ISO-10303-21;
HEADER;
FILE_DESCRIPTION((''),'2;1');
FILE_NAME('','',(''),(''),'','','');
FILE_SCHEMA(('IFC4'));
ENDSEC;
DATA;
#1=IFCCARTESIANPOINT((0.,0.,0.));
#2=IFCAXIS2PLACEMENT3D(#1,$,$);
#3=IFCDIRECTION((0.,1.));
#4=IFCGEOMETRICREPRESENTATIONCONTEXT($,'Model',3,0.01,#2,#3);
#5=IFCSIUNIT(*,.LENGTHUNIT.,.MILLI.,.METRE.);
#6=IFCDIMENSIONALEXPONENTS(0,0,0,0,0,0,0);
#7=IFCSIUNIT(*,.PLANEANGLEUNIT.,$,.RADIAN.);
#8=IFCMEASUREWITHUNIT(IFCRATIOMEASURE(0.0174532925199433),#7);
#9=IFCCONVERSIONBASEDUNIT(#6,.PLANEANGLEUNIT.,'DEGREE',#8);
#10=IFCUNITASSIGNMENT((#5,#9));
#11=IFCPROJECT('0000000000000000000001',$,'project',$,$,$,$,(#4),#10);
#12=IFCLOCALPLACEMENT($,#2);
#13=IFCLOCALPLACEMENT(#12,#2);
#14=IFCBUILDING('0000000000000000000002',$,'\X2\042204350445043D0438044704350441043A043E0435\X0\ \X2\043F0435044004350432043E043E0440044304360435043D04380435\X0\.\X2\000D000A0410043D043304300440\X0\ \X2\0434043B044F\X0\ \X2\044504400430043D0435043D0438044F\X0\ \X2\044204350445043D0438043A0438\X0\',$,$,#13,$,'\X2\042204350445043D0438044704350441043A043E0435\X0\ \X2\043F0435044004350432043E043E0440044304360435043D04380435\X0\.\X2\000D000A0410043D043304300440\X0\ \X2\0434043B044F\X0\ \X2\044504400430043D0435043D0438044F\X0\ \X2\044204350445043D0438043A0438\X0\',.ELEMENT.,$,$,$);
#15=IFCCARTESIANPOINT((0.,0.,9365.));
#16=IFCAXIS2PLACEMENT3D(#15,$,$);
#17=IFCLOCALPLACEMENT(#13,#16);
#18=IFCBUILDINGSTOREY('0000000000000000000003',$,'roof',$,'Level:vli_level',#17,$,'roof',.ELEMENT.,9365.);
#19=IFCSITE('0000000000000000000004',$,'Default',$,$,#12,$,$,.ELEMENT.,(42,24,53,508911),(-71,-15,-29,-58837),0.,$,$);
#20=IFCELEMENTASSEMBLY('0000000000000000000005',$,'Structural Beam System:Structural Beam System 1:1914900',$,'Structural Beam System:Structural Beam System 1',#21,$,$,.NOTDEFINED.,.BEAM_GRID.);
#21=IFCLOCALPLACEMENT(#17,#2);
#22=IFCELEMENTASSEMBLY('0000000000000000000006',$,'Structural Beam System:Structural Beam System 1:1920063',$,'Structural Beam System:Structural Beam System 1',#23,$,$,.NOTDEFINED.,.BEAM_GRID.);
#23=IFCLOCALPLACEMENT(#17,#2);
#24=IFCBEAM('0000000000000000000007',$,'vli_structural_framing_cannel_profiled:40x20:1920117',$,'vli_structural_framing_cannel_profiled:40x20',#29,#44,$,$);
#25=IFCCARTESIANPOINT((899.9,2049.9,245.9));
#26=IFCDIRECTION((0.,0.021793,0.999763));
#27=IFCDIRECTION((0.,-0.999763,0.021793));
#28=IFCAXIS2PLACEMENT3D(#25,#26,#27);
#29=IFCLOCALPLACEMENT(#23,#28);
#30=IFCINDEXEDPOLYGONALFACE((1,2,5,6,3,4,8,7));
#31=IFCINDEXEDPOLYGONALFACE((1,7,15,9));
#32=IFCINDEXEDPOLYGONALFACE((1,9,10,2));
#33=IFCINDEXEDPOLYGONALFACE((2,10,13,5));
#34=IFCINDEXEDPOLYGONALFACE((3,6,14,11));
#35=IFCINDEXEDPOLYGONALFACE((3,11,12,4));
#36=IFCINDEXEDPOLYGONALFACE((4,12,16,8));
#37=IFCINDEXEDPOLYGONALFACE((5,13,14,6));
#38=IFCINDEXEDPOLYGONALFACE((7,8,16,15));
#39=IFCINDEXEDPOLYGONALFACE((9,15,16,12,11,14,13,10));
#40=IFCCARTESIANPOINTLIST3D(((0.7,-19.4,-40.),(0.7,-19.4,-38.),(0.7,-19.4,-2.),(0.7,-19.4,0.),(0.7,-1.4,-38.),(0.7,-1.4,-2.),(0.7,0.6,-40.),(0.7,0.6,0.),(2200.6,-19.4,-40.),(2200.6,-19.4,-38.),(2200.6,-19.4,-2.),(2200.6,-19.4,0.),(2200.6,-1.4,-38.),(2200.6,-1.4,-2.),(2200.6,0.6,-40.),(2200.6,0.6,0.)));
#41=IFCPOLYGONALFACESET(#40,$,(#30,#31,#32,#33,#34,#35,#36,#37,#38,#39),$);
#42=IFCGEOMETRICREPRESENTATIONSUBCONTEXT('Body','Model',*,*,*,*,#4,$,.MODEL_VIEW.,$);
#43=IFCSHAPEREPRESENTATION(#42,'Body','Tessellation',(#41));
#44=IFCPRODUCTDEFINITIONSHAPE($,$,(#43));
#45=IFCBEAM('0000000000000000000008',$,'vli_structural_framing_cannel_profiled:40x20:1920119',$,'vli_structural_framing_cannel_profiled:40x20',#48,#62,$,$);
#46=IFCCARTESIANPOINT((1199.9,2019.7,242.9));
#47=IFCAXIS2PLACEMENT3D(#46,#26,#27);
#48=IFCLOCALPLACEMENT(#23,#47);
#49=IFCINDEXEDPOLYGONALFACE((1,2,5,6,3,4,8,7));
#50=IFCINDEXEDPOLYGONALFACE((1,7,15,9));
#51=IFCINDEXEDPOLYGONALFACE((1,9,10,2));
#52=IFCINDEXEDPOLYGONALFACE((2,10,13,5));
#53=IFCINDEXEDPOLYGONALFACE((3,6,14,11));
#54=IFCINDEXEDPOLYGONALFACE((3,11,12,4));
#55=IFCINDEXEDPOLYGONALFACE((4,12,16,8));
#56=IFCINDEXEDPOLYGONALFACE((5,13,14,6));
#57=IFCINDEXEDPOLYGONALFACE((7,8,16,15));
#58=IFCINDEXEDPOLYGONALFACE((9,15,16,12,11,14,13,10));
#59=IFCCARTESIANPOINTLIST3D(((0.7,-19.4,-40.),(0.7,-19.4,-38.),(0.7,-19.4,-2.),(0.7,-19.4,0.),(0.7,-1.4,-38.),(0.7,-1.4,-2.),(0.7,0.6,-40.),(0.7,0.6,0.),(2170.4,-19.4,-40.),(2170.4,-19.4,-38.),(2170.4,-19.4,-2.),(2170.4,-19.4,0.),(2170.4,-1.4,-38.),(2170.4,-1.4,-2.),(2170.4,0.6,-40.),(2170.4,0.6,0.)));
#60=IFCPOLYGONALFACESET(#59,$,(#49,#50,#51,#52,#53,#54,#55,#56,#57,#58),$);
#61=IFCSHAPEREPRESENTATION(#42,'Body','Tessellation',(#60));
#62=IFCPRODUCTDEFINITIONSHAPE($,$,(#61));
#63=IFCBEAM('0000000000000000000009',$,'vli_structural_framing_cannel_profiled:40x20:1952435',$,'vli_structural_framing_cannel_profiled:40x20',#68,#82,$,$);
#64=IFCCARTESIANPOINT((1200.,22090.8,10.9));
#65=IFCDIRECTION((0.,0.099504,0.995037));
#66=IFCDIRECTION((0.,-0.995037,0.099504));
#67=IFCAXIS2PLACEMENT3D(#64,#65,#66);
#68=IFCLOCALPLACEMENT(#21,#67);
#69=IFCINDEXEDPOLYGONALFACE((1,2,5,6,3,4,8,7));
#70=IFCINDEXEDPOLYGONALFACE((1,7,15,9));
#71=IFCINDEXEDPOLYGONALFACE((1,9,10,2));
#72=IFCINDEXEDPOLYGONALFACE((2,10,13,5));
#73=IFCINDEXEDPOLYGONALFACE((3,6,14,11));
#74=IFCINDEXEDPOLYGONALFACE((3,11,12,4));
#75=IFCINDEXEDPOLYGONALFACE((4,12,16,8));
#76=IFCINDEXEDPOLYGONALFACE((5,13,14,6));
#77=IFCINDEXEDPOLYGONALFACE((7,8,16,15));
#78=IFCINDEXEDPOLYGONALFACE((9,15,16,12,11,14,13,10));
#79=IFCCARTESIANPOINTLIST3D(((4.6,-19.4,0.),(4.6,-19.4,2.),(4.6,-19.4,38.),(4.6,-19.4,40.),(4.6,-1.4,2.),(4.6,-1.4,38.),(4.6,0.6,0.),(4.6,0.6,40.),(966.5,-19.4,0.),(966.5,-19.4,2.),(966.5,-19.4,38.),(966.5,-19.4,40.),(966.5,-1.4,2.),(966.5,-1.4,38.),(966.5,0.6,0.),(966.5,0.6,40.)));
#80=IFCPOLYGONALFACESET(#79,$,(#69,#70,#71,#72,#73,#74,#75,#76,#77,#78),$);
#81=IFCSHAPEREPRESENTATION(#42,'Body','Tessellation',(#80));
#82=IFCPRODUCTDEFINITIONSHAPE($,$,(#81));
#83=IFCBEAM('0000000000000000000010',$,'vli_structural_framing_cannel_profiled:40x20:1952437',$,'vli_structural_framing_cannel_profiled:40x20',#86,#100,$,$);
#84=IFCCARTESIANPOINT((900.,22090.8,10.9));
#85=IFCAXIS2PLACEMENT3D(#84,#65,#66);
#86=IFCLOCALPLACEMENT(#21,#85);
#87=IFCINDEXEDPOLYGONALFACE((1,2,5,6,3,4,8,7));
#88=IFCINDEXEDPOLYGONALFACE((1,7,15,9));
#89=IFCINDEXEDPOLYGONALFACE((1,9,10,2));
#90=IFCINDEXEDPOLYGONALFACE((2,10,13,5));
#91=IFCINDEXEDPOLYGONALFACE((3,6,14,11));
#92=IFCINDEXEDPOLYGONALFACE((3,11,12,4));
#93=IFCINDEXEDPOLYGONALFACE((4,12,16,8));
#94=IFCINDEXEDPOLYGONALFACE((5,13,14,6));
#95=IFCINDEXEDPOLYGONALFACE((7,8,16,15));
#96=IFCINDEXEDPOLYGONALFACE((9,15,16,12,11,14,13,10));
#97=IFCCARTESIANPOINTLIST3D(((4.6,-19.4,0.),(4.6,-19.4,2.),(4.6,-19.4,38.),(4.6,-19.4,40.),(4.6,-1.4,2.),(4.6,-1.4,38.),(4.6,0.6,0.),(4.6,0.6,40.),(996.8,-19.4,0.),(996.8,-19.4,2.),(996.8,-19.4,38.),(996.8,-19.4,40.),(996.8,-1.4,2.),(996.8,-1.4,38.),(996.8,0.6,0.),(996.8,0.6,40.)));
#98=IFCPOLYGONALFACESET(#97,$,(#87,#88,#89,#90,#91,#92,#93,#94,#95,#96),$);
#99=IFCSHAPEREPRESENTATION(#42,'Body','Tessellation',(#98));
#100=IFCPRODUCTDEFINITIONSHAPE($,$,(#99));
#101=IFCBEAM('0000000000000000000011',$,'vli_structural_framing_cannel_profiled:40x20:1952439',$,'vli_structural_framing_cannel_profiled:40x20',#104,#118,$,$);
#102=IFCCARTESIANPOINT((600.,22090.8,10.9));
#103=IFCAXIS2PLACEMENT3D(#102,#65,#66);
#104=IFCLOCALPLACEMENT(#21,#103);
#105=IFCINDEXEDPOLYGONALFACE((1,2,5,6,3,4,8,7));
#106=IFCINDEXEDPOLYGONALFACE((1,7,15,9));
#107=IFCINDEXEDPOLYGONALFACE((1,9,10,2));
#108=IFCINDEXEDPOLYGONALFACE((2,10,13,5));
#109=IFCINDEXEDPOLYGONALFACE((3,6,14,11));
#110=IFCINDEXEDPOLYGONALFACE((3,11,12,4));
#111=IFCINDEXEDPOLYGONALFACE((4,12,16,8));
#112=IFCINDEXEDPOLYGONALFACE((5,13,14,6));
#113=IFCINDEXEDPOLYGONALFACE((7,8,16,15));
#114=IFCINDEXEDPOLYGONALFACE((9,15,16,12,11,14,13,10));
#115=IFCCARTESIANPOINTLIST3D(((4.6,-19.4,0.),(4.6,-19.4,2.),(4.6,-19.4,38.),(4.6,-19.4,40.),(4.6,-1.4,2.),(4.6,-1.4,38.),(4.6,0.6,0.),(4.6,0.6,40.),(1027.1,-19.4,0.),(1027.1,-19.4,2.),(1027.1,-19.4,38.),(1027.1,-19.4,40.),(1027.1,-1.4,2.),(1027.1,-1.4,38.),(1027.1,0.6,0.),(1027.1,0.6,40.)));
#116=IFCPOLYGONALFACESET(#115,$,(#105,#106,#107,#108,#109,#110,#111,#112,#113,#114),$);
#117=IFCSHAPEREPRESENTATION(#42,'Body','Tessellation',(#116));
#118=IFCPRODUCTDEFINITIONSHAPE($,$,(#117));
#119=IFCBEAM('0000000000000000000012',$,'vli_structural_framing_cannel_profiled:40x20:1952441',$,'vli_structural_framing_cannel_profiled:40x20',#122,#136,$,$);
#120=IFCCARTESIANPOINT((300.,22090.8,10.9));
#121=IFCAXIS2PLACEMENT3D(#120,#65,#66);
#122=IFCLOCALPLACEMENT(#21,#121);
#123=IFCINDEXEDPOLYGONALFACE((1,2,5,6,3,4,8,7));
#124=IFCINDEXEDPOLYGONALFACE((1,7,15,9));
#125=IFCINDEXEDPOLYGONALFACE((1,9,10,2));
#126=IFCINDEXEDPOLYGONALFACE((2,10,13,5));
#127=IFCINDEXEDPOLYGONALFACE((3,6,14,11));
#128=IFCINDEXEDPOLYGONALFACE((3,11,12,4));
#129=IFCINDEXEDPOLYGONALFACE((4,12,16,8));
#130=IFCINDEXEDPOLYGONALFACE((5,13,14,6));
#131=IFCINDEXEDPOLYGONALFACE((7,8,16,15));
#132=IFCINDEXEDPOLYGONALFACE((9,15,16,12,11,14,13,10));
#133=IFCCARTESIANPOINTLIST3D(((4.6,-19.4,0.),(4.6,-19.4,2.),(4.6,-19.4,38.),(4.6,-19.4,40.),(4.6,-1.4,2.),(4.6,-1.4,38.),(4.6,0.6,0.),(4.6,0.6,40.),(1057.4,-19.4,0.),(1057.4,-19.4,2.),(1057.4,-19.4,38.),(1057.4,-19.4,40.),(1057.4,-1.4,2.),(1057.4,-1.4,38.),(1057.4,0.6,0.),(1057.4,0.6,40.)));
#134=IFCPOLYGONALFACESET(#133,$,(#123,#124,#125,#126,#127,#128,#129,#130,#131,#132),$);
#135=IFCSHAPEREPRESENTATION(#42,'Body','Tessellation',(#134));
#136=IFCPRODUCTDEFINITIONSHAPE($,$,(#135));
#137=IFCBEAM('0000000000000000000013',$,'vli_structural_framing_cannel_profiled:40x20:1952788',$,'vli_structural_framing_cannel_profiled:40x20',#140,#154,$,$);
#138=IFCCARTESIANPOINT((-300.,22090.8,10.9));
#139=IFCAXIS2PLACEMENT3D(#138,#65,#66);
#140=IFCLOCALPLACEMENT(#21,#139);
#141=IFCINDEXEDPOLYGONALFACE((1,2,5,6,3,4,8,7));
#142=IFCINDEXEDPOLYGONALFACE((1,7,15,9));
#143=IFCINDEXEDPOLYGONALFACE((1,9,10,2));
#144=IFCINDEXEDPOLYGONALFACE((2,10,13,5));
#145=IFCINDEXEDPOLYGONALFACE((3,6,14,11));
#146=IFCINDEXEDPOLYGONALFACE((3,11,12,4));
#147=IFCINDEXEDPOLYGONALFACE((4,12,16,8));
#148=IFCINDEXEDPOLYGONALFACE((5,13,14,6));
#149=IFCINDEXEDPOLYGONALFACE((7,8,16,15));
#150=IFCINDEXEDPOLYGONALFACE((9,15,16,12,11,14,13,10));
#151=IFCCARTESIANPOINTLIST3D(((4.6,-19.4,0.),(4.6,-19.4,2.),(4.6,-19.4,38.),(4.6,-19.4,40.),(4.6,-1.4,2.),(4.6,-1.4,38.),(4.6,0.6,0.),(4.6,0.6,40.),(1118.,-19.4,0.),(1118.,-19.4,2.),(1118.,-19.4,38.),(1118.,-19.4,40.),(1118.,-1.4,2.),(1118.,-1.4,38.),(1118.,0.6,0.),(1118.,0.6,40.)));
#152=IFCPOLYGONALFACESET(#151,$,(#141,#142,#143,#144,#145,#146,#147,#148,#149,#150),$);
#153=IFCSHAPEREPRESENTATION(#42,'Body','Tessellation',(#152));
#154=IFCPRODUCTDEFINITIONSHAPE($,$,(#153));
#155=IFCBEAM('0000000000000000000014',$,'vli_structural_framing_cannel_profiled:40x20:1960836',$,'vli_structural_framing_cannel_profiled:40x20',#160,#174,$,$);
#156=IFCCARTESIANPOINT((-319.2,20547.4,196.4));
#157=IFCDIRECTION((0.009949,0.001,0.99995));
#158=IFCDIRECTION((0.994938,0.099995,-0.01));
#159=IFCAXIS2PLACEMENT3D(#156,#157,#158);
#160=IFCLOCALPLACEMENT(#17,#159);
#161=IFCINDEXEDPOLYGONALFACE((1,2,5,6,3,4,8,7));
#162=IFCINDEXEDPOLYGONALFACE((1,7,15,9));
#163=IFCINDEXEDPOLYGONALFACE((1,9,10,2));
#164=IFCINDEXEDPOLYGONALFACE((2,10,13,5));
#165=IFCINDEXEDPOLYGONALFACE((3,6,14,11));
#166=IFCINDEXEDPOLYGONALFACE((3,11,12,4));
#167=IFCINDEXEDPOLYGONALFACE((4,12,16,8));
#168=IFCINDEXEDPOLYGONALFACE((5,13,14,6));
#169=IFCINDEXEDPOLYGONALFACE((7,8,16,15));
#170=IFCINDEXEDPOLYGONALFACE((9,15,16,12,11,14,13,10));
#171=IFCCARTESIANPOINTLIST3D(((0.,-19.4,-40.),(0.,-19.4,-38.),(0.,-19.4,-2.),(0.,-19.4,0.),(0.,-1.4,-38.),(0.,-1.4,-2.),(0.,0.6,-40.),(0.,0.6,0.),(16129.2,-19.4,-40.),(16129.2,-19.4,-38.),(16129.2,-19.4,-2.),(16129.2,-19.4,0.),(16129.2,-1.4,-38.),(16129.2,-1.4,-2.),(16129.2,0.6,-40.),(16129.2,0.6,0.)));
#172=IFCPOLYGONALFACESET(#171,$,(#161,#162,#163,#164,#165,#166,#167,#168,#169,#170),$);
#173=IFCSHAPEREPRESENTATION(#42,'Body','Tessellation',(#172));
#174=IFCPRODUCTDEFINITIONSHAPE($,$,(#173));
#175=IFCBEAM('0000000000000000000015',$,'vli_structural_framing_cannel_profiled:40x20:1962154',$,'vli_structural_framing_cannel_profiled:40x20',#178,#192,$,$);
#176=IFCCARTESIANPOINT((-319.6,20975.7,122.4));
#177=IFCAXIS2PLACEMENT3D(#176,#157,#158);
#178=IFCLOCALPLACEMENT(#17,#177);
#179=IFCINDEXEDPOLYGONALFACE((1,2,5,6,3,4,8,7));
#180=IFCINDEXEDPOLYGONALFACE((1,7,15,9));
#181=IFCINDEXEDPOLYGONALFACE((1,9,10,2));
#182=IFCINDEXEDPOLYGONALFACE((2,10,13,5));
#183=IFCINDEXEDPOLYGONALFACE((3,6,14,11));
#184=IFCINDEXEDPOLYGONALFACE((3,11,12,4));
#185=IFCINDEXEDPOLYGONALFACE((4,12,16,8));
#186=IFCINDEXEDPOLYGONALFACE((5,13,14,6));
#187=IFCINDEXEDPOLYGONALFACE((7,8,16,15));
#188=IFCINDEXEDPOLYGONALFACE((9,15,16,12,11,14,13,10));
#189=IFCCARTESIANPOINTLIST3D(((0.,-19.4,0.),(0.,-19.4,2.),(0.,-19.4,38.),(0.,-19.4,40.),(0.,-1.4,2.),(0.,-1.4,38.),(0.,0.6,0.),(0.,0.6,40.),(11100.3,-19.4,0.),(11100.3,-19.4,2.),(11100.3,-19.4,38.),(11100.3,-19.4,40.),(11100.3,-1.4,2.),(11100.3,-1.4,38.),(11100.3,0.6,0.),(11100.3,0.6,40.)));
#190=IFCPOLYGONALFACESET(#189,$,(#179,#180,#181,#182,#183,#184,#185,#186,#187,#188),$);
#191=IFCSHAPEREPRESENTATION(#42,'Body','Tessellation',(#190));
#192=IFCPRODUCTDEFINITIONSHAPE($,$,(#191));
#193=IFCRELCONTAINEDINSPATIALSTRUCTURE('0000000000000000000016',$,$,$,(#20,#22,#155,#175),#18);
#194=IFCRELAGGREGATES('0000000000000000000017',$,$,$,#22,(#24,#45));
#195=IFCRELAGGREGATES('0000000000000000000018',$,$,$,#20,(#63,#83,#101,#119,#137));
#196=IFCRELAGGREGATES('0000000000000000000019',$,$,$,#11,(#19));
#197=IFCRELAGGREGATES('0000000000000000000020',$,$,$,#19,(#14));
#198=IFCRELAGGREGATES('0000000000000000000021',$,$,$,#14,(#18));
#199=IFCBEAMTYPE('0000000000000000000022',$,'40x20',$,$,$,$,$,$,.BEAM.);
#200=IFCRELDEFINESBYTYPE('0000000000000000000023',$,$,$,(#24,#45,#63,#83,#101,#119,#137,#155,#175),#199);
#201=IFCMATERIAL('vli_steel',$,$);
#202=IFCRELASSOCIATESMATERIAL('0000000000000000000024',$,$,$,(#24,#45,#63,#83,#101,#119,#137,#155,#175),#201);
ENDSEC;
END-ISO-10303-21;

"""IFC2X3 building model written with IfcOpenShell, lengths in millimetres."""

from ifc_helpers import new_model, entity, si_unit, converted_unit, direction, frame, origin, place, context, subcontext, project, spatial, polyline, outline, extrude, material, type_object, element, aggregate, save


model = new_model("IFC2X3")

# Units and contexts
model_context = context("Model", 3, precision=0.01, world=origin(), true_north=direction((0.0, 1.0)))
body_context = subcontext(model_context, "Body", "Model", "MODEL_VIEW")
ifc_project = project(units=[si_unit("LENGTHUNIT", "METRE", prefix="MILLI"), converted_unit("PLANEANGLEUNIT", "DEGREE", entity("IfcRatioMeasure", 0.0174532925199433), si_unit("PLANEANGLEUNIT", "RADIAN"), dimensions=[0, 0, 0, 0, 0, 0, 0])], contexts=[model_context])

# Site, building, storey
site_placement = place(None, origin())
site = spatial("IfcSite", under=ifc_project, at=site_placement, Name="Default", CompositionType="ELEMENT", RefLatitude=(42, 24, 53, 508911), RefLongitude=(-71, -15, -29, -58837), RefElevation=0.0)
building_placement = place(site_placement, origin())
building = spatial("IfcBuilding", under=site, at=building_placement, Name="Техническое перевооружение.\r\nАнгар для хранения техники", LongName="Техническое перевооружение.\r\nАнгар для хранения техники", CompositionType="ELEMENT")
storey_placement = place(building_placement, frame((0.0, 0.0, 9365.0)))
storey = spatial("IfcBuildingStorey", under=building, at=storey_placement, Name="roof", ObjectType="Level:vli_level", LongName="roof", CompositionType="ELEMENT", Elevation=9365.0)

# Element assemblies, beams
assembly_1_placement = place(storey_placement, origin())
assembly_1 = element("IfcElementAssembly", 1, at=assembly_1_placement, inside=storey, Name="Structural Beam System:Structural Beam System 1:1914900", ObjectType="Structural Beam System:Structural Beam System 1", AssemblyPlace="NOTDEFINED", PredefinedType="BEAM_GRID")
ifc_material = material(Name="vli_steel")
beam_type = type_object("IfcBeamType", Name="40x20", PredefinedType="BEAM")
assembly_2_placement = place(storey_placement, origin())
assembly_2 = element("IfcElementAssembly", 2, at=assembly_2_placement, inside=storey, Name="Structural Beam System:Structural Beam System 1:1920063", ObjectType="Structural Beam System:Structural Beam System 1", AssemblyPlace="NOTDEFINED", PredefinedType="BEAM_GRID")
beam_1_placement = place(assembly_2_placement, frame((899.9, 2049.9, 245.9), z_axis=(0.0, 0.021793, 0.999763), x_axis=(0.0, -0.999763, 0.021793)))
beam_1 = element("IfcBeam", 3, at=beam_1_placement, type_object=beam_type, material=ifc_material, Name="vli_structural_framing_cannel_profiled:40x20:1920117", ObjectType="vli_structural_framing_cannel_profiled:40x20", context=body_context, shape_type="SweptSolid", body=[
    extrude(outline(polyline([(-20.0, -9.5), (-18.0, -9.5), (-18.0, 8.5), (18.0, 8.5), (18.0, -9.5), (20.0, -9.5), (20.0, 10.5), (-20.0, 10.5), (-20.0, -9.5)])), frame((0.7, -9.9, -20.0), z_axis=(1.0, 0.0, 0.0), x_axis=(0.0, 0.0, -1.0)), (0.0, 0.0, 1.0), 2199.9),
])
beam_2_placement = place(assembly_2_placement, frame((1199.9, 2019.7, 242.9), z_axis=(0.0, 0.021793, 0.999763), x_axis=(0.0, -0.999763, 0.021793)))
beam_2 = element("IfcBeam", 4, at=beam_2_placement, type_object=beam_type, material=ifc_material, Name="vli_structural_framing_cannel_profiled:40x20:1920119", ObjectType="vli_structural_framing_cannel_profiled:40x20", context=body_context, shape_type="SweptSolid", body=[
    extrude(outline(polyline([(-20.0, -9.5), (-18.0, -9.5), (-18.0, 8.5), (18.0, 8.5), (18.0, -9.5), (20.0, -9.5), (20.0, 10.5), (-20.0, 10.5), (-20.0, -9.5)])), frame((0.7, -9.9, -20.0), z_axis=(1.0, 0.0, 0.0), x_axis=(0.0, 0.0, -1.0)), (0.0, 0.0, 1.0), 2169.8),
])
aggregate(assembly_2, [beam_1, beam_2])

# Beams
beam_3_placement = place(assembly_1_placement, frame((1200.0, 22090.8, 10.9), z_axis=(0.0, 0.099504, 0.995037), x_axis=(0.0, -0.995037, 0.099504)))
beam_3 = element("IfcBeam", 5, at=beam_3_placement, type_object=beam_type, material=ifc_material, Name="vli_structural_framing_cannel_profiled:40x20:1952435", ObjectType="vli_structural_framing_cannel_profiled:40x20", context=body_context, shape_type="SweptSolid", body=[
    extrude(outline(polyline([(-20.0, -9.5), (-18.0, -9.5), (-18.0, 8.5), (18.0, 8.5), (18.0, -9.5), (20.0, -9.5), (20.0, 10.5), (-20.0, 10.5), (-20.0, -9.5)])), frame((4.6, -9.9, 20.0), z_axis=(1.0, 0.0, 0.0), x_axis=(0.0, 0.0, -1.0)), (0.0, 0.0, 1.0), 962.0),
])
beam_4_placement = place(assembly_1_placement, frame((900.0, 22090.8, 10.9), z_axis=(0.0, 0.099504, 0.995037), x_axis=(0.0, -0.995037, 0.099504)))
beam_4 = element("IfcBeam", 6, at=beam_4_placement, type_object=beam_type, material=ifc_material, Name="vli_structural_framing_cannel_profiled:40x20:1952437", ObjectType="vli_structural_framing_cannel_profiled:40x20", context=body_context, shape_type="SweptSolid", body=[
    extrude(outline(polyline([(-20.0, -9.5), (-18.0, -9.5), (-18.0, 8.5), (18.0, 8.5), (18.0, -9.5), (20.0, -9.5), (20.0, 10.5), (-20.0, 10.5), (-20.0, -9.5)])), frame((4.6, -9.9, 20.0), z_axis=(1.0, 0.0, 0.0), x_axis=(0.0, 0.0, -1.0)), (0.0, 0.0, 1.0), 992.3),
])
beam_5_placement = place(assembly_1_placement, frame((600.0, 22090.8, 10.9), z_axis=(0.0, 0.099504, 0.995037), x_axis=(0.0, -0.995037, 0.099504)))
beam_5 = element("IfcBeam", 7, at=beam_5_placement, type_object=beam_type, material=ifc_material, Name="vli_structural_framing_cannel_profiled:40x20:1952439", ObjectType="vli_structural_framing_cannel_profiled:40x20", context=body_context, shape_type="SweptSolid", body=[
    extrude(outline(polyline([(-20.0, -9.5), (-18.0, -9.5), (-18.0, 8.5), (18.0, 8.5), (18.0, -9.5), (20.0, -9.5), (20.0, 10.5), (-20.0, 10.5), (-20.0, -9.5)])), frame((4.6, -9.9, 20.0), z_axis=(1.0, 0.0, 0.0), x_axis=(0.0, 0.0, -1.0)), (0.0, 0.0, 1.0), 1022.6),
])
beam_6_placement = place(assembly_1_placement, frame((300.0, 22090.8, 10.9), z_axis=(0.0, 0.099504, 0.995037), x_axis=(0.0, -0.995037, 0.099504)))
beam_6 = element("IfcBeam", 8, at=beam_6_placement, type_object=beam_type, material=ifc_material, Name="vli_structural_framing_cannel_profiled:40x20:1952441", ObjectType="vli_structural_framing_cannel_profiled:40x20", context=body_context, shape_type="SweptSolid", body=[
    extrude(outline(polyline([(-20.0, -9.5), (-18.0, -9.5), (-18.0, 8.5), (18.0, 8.5), (18.0, -9.5), (20.0, -9.5), (20.0, 10.5), (-20.0, 10.5), (-20.0, -9.5)])), frame((4.6, -9.9, 20.0), z_axis=(1.0, 0.0, 0.0), x_axis=(0.0, 0.0, -1.0)), (0.0, 0.0, 1.0), 1052.9),
])
beam_7_placement = place(assembly_1_placement, frame((-300.0, 22090.8, 10.9), z_axis=(0.0, 0.099504, 0.995037), x_axis=(0.0, -0.995037, 0.099504)))
beam_7 = element("IfcBeam", 9, at=beam_7_placement, type_object=beam_type, material=ifc_material, Name="vli_structural_framing_cannel_profiled:40x20:1952788", ObjectType="vli_structural_framing_cannel_profiled:40x20", context=body_context, shape_type="SweptSolid", body=[
    extrude(outline(polyline([(-20.0, -9.5), (-18.0, -9.5), (-18.0, 8.5), (18.0, 8.5), (18.0, -9.5), (20.0, -9.5), (20.0, 10.5), (-20.0, 10.5), (-20.0, -9.5)])), frame((4.6, -9.9, 20.0), z_axis=(1.0, 0.0, 0.0), x_axis=(0.0, 0.0, -1.0)), (0.0, 0.0, 1.0), 1113.5),
])
aggregate(assembly_1, [beam_3, beam_4, beam_5, beam_6, beam_7])

# Beams
beam_8_placement = place(storey_placement, frame((-319.2, 20547.4, 196.4), z_axis=(0.009949, 0.001, 0.99995), x_axis=(0.994938, 0.099995, -0.01)))
element("IfcBeam", 10, at=beam_8_placement, inside=storey, type_object=beam_type, material=ifc_material, Name="vli_structural_framing_cannel_profiled:40x20:1960836", ObjectType="vli_structural_framing_cannel_profiled:40x20", context=body_context, shape_type="SweptSolid", body=[
    extrude(outline(polyline([(-20.0, -9.5), (-18.0, -9.5), (-18.0, 8.5), (18.0, 8.5), (18.0, -9.5), (20.0, -9.5), (20.0, 10.5), (-20.0, 10.5), (-20.0, -9.5)])), frame((0.0, -9.9, -20.0), z_axis=(1.0, 0.0, 0.0), x_axis=(0.0, 0.0, -1.0)), (0.0, 0.0, 1.0), 16129.2),
])
beam_9_placement = place(storey_placement, frame((-319.6, 20975.7, 122.4), z_axis=(0.009949, 0.001, 0.99995), x_axis=(0.994938, 0.099995, -0.01)))
element("IfcBeam", 11, at=beam_9_placement, inside=storey, type_object=beam_type, material=ifc_material, Name="vli_structural_framing_cannel_profiled:40x20:1962154", ObjectType="vli_structural_framing_cannel_profiled:40x20", context=body_context, shape_type="SweptSolid", body=[
    extrude(outline(polyline([(-20.0, -9.5), (-18.0, -9.5), (-18.0, 8.5), (18.0, 8.5), (18.0, -9.5), (20.0, -9.5), (20.0, 10.5), (-20.0, 10.5), (-20.0, -9.5)])), frame((0.0, -9.9, 20.0), z_axis=(1.0, 0.0, 0.0), x_axis=(0.0, 0.0, -1.0)), (0.0, 0.0, 1.0), 11100.3),
])

save(model, "model.ifc")
